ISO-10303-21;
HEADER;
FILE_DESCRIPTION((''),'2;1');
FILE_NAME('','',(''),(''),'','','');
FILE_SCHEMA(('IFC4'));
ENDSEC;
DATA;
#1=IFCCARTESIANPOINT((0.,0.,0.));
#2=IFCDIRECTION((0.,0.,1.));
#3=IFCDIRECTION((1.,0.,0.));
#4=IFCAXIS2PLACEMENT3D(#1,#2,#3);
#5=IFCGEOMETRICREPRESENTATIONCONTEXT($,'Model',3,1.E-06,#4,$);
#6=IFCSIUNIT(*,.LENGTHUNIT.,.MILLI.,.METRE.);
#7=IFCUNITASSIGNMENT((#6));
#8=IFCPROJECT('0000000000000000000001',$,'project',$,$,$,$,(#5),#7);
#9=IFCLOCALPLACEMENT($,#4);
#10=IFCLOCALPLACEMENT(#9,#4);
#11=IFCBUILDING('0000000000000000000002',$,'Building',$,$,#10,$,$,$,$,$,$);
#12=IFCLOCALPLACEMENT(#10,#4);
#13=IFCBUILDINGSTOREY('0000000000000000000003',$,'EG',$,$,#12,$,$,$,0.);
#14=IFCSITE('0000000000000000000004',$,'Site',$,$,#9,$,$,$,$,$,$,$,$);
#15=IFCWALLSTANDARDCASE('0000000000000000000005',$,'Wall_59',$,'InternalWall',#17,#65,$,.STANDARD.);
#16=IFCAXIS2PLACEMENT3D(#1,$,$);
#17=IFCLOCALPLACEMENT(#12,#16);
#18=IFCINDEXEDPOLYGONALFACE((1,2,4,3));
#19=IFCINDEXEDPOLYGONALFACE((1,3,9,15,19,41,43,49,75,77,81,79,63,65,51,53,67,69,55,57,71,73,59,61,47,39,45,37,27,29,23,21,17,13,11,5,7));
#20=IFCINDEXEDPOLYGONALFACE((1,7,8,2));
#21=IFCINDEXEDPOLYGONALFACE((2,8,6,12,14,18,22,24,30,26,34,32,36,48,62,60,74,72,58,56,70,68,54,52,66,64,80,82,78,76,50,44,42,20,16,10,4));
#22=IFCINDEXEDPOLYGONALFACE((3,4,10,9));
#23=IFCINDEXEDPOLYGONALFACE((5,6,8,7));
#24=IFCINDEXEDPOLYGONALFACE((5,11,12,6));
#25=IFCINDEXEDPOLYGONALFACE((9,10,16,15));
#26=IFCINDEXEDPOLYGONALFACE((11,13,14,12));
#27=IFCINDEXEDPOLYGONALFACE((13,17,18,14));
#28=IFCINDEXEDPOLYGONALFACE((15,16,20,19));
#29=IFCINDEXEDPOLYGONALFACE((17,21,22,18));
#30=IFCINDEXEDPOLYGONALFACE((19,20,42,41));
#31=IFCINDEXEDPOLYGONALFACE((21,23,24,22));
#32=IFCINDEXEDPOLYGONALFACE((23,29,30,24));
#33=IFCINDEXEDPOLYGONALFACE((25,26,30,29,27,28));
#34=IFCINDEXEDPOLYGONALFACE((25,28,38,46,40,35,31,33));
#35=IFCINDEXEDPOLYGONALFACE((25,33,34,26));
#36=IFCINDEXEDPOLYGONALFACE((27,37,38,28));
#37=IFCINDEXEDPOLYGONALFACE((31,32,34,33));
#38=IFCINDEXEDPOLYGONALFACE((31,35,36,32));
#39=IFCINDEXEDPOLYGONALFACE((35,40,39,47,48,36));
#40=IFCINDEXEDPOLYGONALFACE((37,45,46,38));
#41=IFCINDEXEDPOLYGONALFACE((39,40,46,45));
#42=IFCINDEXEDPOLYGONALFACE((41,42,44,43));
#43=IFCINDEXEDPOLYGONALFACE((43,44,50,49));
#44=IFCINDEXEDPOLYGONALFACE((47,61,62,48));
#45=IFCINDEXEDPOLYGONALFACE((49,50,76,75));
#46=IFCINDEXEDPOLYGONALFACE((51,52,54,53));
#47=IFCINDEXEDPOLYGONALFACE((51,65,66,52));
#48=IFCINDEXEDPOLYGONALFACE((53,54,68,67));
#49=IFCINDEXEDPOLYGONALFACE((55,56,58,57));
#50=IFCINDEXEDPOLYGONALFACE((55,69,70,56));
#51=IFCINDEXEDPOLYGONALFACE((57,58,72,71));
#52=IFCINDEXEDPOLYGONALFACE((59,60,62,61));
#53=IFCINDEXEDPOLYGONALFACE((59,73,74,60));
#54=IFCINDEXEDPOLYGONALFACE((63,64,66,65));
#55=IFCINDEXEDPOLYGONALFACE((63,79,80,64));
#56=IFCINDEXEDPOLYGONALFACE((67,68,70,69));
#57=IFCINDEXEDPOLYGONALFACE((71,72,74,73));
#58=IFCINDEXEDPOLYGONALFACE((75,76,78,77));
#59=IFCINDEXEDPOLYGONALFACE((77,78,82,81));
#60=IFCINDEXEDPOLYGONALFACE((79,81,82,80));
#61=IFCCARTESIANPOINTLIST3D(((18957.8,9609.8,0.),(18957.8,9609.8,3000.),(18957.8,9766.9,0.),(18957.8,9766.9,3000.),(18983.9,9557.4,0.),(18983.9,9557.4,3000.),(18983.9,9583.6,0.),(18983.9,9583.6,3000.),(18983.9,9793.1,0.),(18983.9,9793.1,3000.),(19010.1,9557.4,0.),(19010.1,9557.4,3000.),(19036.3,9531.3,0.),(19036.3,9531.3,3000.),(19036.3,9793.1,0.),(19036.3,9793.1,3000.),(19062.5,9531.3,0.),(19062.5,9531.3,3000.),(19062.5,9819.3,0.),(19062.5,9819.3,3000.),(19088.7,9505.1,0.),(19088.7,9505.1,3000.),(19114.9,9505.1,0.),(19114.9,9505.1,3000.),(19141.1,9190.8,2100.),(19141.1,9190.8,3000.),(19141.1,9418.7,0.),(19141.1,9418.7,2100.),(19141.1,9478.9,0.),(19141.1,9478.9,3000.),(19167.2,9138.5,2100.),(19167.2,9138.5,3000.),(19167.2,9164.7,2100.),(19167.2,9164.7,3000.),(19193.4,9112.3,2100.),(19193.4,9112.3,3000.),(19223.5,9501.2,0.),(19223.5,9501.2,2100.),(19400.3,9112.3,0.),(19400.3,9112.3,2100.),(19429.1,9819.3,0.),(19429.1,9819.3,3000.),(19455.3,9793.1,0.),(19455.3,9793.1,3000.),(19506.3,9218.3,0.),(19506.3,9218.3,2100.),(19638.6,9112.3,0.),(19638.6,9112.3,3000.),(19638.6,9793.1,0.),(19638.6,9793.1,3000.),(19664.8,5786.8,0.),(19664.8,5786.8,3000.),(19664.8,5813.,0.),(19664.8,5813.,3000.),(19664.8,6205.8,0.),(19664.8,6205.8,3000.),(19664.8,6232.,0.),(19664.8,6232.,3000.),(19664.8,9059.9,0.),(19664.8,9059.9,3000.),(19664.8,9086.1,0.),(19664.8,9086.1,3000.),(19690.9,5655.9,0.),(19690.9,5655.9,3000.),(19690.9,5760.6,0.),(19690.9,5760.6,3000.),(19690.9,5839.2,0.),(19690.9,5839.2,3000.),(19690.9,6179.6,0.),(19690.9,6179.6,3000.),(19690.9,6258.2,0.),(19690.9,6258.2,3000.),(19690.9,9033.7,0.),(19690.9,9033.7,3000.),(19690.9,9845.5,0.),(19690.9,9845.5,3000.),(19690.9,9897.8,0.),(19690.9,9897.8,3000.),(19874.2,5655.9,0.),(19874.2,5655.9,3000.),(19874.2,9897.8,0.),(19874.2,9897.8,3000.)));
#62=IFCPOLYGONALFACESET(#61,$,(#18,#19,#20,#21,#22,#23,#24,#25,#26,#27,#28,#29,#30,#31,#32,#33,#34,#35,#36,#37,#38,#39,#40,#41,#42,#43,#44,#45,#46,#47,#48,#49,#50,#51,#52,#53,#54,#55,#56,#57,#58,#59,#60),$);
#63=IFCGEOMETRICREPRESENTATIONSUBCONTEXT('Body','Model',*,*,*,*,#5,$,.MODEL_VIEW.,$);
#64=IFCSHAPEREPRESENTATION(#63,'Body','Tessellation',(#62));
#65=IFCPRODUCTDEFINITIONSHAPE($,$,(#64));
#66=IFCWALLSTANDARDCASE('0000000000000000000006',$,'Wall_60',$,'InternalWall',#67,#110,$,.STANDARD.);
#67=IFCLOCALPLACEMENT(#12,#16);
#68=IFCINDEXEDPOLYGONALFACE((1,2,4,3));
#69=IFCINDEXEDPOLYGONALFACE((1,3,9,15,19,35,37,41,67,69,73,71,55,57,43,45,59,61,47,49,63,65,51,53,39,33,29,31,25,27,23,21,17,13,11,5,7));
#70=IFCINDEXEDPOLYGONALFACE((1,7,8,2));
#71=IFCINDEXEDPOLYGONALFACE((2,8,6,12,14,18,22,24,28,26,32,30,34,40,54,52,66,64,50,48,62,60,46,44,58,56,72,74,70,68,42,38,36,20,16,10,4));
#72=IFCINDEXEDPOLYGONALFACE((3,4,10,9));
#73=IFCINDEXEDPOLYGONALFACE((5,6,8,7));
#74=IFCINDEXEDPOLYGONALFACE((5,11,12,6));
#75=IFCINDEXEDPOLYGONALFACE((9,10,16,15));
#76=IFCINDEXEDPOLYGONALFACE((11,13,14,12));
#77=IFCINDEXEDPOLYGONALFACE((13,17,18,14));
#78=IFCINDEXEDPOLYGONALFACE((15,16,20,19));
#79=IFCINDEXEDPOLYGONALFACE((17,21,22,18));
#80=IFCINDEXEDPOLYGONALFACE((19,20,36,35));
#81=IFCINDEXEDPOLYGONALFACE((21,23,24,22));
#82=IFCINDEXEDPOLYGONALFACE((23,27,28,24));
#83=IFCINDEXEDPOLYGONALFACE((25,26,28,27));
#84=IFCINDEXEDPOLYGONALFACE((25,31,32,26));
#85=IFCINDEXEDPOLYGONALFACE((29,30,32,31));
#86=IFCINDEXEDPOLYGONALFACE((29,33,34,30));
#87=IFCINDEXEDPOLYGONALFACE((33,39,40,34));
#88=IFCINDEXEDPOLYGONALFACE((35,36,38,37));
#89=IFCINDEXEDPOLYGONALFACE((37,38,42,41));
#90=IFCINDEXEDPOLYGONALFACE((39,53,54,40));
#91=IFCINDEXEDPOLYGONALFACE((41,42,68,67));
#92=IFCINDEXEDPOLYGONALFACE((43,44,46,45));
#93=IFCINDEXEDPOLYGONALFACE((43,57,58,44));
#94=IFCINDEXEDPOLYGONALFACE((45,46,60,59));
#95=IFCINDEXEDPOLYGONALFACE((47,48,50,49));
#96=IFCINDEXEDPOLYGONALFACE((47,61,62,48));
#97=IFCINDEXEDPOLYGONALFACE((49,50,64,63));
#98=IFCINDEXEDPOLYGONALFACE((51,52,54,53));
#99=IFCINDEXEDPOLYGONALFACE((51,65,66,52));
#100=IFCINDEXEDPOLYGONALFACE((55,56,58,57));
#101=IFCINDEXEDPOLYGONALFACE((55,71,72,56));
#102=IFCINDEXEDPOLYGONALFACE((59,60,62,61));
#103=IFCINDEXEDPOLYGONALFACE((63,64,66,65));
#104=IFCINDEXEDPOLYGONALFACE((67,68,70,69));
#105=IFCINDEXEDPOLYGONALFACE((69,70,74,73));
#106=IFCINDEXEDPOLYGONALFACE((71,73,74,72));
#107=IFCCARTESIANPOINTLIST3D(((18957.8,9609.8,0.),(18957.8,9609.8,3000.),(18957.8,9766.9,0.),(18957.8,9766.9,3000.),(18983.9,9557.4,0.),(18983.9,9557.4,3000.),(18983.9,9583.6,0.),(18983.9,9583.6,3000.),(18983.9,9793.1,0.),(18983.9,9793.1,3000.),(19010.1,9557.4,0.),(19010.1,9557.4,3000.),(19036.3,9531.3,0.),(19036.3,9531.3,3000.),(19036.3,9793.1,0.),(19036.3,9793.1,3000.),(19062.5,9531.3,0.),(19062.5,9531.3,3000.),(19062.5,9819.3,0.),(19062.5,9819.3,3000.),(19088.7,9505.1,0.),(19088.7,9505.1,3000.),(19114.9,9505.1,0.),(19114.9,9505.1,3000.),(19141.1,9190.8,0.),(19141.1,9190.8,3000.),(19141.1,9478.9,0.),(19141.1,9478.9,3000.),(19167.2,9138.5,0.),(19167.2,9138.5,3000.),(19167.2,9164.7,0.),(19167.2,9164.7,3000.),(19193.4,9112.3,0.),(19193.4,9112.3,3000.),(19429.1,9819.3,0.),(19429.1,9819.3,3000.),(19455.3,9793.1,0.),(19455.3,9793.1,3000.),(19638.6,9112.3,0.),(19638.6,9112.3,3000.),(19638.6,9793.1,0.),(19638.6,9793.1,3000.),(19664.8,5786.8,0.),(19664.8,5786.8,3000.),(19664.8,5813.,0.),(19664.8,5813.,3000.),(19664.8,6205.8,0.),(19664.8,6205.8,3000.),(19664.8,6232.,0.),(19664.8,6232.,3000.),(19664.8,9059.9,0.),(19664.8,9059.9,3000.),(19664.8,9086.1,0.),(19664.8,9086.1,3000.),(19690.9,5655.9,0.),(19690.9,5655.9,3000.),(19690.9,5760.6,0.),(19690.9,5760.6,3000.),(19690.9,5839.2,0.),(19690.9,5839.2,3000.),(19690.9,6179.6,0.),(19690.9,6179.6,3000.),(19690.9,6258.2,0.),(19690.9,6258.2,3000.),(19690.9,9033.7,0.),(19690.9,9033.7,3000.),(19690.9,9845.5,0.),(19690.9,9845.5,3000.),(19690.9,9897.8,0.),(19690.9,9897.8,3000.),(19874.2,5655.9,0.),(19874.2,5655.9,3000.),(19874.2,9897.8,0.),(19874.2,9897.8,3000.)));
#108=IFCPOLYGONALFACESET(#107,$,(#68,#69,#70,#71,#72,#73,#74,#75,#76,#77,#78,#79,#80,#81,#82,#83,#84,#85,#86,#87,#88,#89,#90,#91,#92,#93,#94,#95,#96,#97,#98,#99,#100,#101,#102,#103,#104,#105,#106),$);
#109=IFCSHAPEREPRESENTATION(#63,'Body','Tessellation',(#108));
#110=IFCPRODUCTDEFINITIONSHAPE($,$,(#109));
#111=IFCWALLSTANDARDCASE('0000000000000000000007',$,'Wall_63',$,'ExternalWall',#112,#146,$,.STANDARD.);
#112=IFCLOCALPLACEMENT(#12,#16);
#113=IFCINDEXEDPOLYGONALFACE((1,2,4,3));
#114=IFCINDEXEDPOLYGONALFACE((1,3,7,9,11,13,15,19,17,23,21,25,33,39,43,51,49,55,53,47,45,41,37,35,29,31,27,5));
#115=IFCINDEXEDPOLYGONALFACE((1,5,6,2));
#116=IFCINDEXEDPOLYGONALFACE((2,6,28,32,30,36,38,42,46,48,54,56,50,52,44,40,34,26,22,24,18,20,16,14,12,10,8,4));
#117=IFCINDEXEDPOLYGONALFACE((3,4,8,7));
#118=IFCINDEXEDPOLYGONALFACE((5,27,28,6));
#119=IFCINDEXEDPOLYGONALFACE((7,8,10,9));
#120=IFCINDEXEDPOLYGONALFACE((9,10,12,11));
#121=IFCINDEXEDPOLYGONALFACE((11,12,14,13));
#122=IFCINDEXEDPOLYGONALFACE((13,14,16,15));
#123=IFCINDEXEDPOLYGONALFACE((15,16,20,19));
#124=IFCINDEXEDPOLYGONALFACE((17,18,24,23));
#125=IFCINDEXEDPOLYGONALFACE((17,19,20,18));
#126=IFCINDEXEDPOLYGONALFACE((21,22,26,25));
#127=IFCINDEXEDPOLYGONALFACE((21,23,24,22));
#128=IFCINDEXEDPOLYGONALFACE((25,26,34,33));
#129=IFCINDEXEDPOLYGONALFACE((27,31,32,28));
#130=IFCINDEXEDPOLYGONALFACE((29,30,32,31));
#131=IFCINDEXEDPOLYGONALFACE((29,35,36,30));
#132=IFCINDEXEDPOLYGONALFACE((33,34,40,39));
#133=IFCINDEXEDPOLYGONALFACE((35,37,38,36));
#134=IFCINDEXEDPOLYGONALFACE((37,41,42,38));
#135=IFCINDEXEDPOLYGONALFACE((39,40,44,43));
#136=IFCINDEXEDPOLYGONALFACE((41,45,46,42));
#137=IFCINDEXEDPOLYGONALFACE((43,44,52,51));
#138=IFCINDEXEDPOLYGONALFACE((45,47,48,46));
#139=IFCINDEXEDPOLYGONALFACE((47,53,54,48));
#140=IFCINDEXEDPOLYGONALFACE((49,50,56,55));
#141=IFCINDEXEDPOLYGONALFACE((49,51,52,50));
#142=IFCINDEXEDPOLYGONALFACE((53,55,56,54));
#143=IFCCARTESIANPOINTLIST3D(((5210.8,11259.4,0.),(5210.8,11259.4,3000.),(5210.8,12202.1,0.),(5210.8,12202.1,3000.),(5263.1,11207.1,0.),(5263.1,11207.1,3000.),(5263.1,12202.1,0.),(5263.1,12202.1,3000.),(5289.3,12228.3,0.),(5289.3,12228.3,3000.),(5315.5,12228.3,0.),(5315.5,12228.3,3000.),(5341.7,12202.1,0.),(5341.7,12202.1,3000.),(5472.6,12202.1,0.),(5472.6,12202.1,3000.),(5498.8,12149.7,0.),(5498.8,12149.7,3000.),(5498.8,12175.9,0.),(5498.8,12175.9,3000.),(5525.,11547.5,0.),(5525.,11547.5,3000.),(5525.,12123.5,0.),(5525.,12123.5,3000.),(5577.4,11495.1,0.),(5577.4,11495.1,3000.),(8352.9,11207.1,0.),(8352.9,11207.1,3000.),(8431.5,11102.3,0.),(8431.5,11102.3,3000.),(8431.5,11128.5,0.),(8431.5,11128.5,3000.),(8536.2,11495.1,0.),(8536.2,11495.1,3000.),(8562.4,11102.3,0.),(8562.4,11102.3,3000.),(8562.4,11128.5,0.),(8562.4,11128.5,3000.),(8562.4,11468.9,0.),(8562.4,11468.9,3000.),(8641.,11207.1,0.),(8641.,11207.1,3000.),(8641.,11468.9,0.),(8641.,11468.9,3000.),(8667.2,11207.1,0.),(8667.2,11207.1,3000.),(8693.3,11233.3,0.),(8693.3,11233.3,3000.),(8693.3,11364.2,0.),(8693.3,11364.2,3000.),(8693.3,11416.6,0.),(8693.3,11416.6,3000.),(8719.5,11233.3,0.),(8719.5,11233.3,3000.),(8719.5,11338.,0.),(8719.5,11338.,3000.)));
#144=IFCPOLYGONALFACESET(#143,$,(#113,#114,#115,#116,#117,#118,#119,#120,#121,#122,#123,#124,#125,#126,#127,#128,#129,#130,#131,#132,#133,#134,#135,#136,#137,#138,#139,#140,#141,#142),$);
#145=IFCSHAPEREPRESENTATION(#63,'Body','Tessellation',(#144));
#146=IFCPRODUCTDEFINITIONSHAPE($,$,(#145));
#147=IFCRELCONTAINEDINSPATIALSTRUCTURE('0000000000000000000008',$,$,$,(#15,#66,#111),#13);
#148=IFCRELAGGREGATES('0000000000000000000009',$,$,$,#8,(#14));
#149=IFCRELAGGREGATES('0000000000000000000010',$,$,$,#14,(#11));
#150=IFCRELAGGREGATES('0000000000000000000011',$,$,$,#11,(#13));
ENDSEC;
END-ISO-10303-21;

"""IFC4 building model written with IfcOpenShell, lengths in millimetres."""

from ifc_helpers import new_model, si_unit, frame, origin_with_axes, place, context, subcontext, project, spatial, polyline, rectangle, outline, extrude, element, save


model = new_model("IFC4")

# Units and contexts
model_context = context("Model", 3, precision=1e-06, world=origin_with_axes())
body_context = subcontext(model_context, "Body", "Model", "MODEL_VIEW")
ifc_project = project(units=[si_unit("LENGTHUNIT", "METRE", prefix="MILLI")], contexts=[model_context])

# Site, building, storey
site_placement = place(None, origin_with_axes())
site = spatial("IfcSite", under=ifc_project, at=site_placement, Name="Site")
building_placement = place(site_placement, origin_with_axes())
building = spatial("IfcBuilding", under=site, at=building_placement, Name="Building")
storey_placement = place(building_placement, origin_with_axes())
storey = spatial("IfcBuildingStorey", under=building, at=storey_placement, Name="EG", Elevation=0.0)

# Wall, opening
wall_1_placement = place(storey_placement, origin_with_axes())
wall_1 = element("IfcWallStandardCase", 1, at=wall_1_placement, inside=storey, Name="Wall_59", ObjectType="InternalWall", PredefinedType="STANDARD", context=body_context, shape_type="SweptSolid", body=[
    extrude(outline(polyline([(19690.9, 5655.9, 0.0), (19690.9, 5760.6, 0.0), (19664.8, 5786.8, 0.0), (19664.8, 5813.0, 0.0), (19690.9, 5839.2, 0.0), (19690.9, 6179.6, 0.0), (19664.8, 6205.8, 0.0), (19664.8, 6232.0, 0.0), (19690.9, 6258.2, 0.0), (19690.9, 9033.7, 0.0), (19664.8, 9059.9, 0.0), (19664.8, 9086.1, 0.0), (19638.6, 9112.3, 0.0), (19193.4, 9112.3, 0.0), (19167.2, 9138.5, 0.0), (19167.2, 9164.7, 0.0), (19141.1, 9190.8, 0.0), (19141.1, 9478.9, 0.0), (19114.9, 9505.1, 0.0), (19088.7, 9505.1, 0.0), (19062.5, 9531.3, 0.0), (19036.3, 9531.3, 0.0), (19010.1, 9557.4, 0.0), (18983.9, 9557.4, 0.0), (18983.9, 9583.6, 0.0), (18957.8, 9609.8, 0.0), (18957.8, 9766.9, 0.0), (18983.9, 9793.1, 0.0), (19036.3, 9793.1, 0.0), (19062.5, 9819.3, 0.0), (19429.1, 9819.3, 0.0), (19455.3, 9793.1, 0.0), (19638.6, 9793.1, 0.0), (19690.9, 9845.5, 0.0), (19690.9, 9897.8, 0.0), (19874.2, 9897.8, 0.0), (19874.2, 5655.9, 0.0), (19690.9, 5655.9, 0.0)])), origin_with_axes(), (0.0, 0.0, 1.0), 3000.0),
])
opening_1_placement = place(wall_1_placement, origin_with_axes())
element("IfcOpeningElement", 2, at=opening_1_placement, inside=storey, cuts=wall_1, context=body_context, shape_type="SweptSolid", body=[
    extrude(rectangle(XDim=1036.9, YDim=400.0), frame((18998.3, 8993.2, 0.0), z_axis=(0.0, 0.0, 1.0), x_axis=(-0.707107, -0.707107, 0.0)), (0.0, 0.0, 1.0), 2100.0),
])

# Walls
for number, where, z_axis, x_axis, name in (
    (3, (0.0, 0.0, 0.0), (0.0, 0.0, 1.0), (1.0, 0.0, 0.0), "Wall_60"),
):
    element("IfcWallStandardCase", number, at=place(storey_placement, frame(where, z_axis=z_axis, x_axis=x_axis)), inside=storey, Name=name, ObjectType="InternalWall", PredefinedType="STANDARD", context=body_context, shape_type="SweptSolid", body=[
        extrude(outline(polyline([(19690.9, 5655.9, 0.0), (19690.9, 5760.6, 0.0), (19664.8, 5786.8, 0.0), (19664.8, 5813.0, 0.0), (19690.9, 5839.2, 0.0), (19690.9, 6179.6, 0.0), (19664.8, 6205.8, 0.0), (19664.8, 6232.0, 0.0), (19690.9, 6258.2, 0.0), (19690.9, 9033.7, 0.0), (19664.8, 9059.9, 0.0), (19664.8, 9086.1, 0.0), (19638.6, 9112.3, 0.0), (19193.4, 9112.3, 0.0), (19167.2, 9138.5, 0.0), (19167.2, 9164.7, 0.0), (19141.1, 9190.8, 0.0), (19141.1, 9478.9, 0.0), (19114.9, 9505.1, 0.0), (19088.7, 9505.1, 0.0), (19062.5, 9531.3, 0.0), (19036.3, 9531.3, 0.0), (19010.1, 9557.4, 0.0), (18983.9, 9557.4, 0.0), (18983.9, 9583.6, 0.0), (18957.8, 9609.8, 0.0), (18957.8, 9766.9, 0.0), (18983.9, 9793.1, 0.0), (19036.3, 9793.1, 0.0), (19062.5, 9819.3, 0.0), (19429.1, 9819.3, 0.0), (19455.3, 9793.1, 0.0), (19638.6, 9793.1, 0.0), (19690.9, 9845.5, 0.0), (19690.9, 9897.8, 0.0), (19874.2, 9897.8, 0.0), (19874.2, 5655.9, 0.0), (19690.9, 5655.9, 0.0)])), origin_with_axes(), (0.0, 0.0, 1.0), 3000.0),
    ])
wall_2_placement = place(storey_placement, origin_with_axes())
element("IfcWallStandardCase", 4, at=wall_2_placement, inside=storey, Name="Wall_63", ObjectType="ExternalWall", PredefinedType="STANDARD", context=body_context, shape_type="SweptSolid", body=[
    extrude(outline(polyline([(8431.5, 11102.3, 0.0), (8431.5, 11128.5, 0.0), (8352.9, 11207.1, 0.0), (5263.1, 11207.1, 0.0), (5210.8, 11259.4, 0.0), (5210.8, 12202.1, 0.0), (5263.1, 12202.1, 0.0), (5289.3, 12228.3, 0.0), (5315.5, 12228.3, 0.0), (5341.7, 12202.1, 0.0), (5472.6, 12202.1, 0.0), (5498.8, 12175.9, 0.0), (5498.8, 12149.7, 0.0), (5525.0, 12123.5, 0.0), (5525.0, 11547.5, 0.0), (5577.4, 11495.1, 0.0), (8536.2, 11495.1, 0.0), (8562.4, 11468.9, 0.0), (8641.0, 11468.9, 0.0), (8693.3, 11416.6, 0.0), (8693.3, 11364.2, 0.0), (8719.5, 11338.0, 0.0), (8719.5, 11233.3, 0.0), (8693.3, 11233.3, 0.0), (8667.2, 11207.1, 0.0), (8641.0, 11207.1, 0.0), (8562.4, 11128.5, 0.0), (8562.4, 11102.3, 0.0), (8431.5, 11102.3, 0.0)])), origin_with_axes(), (0.0, 0.0, 1.0), 3000.0),
])

save(model, "model.ifc")
